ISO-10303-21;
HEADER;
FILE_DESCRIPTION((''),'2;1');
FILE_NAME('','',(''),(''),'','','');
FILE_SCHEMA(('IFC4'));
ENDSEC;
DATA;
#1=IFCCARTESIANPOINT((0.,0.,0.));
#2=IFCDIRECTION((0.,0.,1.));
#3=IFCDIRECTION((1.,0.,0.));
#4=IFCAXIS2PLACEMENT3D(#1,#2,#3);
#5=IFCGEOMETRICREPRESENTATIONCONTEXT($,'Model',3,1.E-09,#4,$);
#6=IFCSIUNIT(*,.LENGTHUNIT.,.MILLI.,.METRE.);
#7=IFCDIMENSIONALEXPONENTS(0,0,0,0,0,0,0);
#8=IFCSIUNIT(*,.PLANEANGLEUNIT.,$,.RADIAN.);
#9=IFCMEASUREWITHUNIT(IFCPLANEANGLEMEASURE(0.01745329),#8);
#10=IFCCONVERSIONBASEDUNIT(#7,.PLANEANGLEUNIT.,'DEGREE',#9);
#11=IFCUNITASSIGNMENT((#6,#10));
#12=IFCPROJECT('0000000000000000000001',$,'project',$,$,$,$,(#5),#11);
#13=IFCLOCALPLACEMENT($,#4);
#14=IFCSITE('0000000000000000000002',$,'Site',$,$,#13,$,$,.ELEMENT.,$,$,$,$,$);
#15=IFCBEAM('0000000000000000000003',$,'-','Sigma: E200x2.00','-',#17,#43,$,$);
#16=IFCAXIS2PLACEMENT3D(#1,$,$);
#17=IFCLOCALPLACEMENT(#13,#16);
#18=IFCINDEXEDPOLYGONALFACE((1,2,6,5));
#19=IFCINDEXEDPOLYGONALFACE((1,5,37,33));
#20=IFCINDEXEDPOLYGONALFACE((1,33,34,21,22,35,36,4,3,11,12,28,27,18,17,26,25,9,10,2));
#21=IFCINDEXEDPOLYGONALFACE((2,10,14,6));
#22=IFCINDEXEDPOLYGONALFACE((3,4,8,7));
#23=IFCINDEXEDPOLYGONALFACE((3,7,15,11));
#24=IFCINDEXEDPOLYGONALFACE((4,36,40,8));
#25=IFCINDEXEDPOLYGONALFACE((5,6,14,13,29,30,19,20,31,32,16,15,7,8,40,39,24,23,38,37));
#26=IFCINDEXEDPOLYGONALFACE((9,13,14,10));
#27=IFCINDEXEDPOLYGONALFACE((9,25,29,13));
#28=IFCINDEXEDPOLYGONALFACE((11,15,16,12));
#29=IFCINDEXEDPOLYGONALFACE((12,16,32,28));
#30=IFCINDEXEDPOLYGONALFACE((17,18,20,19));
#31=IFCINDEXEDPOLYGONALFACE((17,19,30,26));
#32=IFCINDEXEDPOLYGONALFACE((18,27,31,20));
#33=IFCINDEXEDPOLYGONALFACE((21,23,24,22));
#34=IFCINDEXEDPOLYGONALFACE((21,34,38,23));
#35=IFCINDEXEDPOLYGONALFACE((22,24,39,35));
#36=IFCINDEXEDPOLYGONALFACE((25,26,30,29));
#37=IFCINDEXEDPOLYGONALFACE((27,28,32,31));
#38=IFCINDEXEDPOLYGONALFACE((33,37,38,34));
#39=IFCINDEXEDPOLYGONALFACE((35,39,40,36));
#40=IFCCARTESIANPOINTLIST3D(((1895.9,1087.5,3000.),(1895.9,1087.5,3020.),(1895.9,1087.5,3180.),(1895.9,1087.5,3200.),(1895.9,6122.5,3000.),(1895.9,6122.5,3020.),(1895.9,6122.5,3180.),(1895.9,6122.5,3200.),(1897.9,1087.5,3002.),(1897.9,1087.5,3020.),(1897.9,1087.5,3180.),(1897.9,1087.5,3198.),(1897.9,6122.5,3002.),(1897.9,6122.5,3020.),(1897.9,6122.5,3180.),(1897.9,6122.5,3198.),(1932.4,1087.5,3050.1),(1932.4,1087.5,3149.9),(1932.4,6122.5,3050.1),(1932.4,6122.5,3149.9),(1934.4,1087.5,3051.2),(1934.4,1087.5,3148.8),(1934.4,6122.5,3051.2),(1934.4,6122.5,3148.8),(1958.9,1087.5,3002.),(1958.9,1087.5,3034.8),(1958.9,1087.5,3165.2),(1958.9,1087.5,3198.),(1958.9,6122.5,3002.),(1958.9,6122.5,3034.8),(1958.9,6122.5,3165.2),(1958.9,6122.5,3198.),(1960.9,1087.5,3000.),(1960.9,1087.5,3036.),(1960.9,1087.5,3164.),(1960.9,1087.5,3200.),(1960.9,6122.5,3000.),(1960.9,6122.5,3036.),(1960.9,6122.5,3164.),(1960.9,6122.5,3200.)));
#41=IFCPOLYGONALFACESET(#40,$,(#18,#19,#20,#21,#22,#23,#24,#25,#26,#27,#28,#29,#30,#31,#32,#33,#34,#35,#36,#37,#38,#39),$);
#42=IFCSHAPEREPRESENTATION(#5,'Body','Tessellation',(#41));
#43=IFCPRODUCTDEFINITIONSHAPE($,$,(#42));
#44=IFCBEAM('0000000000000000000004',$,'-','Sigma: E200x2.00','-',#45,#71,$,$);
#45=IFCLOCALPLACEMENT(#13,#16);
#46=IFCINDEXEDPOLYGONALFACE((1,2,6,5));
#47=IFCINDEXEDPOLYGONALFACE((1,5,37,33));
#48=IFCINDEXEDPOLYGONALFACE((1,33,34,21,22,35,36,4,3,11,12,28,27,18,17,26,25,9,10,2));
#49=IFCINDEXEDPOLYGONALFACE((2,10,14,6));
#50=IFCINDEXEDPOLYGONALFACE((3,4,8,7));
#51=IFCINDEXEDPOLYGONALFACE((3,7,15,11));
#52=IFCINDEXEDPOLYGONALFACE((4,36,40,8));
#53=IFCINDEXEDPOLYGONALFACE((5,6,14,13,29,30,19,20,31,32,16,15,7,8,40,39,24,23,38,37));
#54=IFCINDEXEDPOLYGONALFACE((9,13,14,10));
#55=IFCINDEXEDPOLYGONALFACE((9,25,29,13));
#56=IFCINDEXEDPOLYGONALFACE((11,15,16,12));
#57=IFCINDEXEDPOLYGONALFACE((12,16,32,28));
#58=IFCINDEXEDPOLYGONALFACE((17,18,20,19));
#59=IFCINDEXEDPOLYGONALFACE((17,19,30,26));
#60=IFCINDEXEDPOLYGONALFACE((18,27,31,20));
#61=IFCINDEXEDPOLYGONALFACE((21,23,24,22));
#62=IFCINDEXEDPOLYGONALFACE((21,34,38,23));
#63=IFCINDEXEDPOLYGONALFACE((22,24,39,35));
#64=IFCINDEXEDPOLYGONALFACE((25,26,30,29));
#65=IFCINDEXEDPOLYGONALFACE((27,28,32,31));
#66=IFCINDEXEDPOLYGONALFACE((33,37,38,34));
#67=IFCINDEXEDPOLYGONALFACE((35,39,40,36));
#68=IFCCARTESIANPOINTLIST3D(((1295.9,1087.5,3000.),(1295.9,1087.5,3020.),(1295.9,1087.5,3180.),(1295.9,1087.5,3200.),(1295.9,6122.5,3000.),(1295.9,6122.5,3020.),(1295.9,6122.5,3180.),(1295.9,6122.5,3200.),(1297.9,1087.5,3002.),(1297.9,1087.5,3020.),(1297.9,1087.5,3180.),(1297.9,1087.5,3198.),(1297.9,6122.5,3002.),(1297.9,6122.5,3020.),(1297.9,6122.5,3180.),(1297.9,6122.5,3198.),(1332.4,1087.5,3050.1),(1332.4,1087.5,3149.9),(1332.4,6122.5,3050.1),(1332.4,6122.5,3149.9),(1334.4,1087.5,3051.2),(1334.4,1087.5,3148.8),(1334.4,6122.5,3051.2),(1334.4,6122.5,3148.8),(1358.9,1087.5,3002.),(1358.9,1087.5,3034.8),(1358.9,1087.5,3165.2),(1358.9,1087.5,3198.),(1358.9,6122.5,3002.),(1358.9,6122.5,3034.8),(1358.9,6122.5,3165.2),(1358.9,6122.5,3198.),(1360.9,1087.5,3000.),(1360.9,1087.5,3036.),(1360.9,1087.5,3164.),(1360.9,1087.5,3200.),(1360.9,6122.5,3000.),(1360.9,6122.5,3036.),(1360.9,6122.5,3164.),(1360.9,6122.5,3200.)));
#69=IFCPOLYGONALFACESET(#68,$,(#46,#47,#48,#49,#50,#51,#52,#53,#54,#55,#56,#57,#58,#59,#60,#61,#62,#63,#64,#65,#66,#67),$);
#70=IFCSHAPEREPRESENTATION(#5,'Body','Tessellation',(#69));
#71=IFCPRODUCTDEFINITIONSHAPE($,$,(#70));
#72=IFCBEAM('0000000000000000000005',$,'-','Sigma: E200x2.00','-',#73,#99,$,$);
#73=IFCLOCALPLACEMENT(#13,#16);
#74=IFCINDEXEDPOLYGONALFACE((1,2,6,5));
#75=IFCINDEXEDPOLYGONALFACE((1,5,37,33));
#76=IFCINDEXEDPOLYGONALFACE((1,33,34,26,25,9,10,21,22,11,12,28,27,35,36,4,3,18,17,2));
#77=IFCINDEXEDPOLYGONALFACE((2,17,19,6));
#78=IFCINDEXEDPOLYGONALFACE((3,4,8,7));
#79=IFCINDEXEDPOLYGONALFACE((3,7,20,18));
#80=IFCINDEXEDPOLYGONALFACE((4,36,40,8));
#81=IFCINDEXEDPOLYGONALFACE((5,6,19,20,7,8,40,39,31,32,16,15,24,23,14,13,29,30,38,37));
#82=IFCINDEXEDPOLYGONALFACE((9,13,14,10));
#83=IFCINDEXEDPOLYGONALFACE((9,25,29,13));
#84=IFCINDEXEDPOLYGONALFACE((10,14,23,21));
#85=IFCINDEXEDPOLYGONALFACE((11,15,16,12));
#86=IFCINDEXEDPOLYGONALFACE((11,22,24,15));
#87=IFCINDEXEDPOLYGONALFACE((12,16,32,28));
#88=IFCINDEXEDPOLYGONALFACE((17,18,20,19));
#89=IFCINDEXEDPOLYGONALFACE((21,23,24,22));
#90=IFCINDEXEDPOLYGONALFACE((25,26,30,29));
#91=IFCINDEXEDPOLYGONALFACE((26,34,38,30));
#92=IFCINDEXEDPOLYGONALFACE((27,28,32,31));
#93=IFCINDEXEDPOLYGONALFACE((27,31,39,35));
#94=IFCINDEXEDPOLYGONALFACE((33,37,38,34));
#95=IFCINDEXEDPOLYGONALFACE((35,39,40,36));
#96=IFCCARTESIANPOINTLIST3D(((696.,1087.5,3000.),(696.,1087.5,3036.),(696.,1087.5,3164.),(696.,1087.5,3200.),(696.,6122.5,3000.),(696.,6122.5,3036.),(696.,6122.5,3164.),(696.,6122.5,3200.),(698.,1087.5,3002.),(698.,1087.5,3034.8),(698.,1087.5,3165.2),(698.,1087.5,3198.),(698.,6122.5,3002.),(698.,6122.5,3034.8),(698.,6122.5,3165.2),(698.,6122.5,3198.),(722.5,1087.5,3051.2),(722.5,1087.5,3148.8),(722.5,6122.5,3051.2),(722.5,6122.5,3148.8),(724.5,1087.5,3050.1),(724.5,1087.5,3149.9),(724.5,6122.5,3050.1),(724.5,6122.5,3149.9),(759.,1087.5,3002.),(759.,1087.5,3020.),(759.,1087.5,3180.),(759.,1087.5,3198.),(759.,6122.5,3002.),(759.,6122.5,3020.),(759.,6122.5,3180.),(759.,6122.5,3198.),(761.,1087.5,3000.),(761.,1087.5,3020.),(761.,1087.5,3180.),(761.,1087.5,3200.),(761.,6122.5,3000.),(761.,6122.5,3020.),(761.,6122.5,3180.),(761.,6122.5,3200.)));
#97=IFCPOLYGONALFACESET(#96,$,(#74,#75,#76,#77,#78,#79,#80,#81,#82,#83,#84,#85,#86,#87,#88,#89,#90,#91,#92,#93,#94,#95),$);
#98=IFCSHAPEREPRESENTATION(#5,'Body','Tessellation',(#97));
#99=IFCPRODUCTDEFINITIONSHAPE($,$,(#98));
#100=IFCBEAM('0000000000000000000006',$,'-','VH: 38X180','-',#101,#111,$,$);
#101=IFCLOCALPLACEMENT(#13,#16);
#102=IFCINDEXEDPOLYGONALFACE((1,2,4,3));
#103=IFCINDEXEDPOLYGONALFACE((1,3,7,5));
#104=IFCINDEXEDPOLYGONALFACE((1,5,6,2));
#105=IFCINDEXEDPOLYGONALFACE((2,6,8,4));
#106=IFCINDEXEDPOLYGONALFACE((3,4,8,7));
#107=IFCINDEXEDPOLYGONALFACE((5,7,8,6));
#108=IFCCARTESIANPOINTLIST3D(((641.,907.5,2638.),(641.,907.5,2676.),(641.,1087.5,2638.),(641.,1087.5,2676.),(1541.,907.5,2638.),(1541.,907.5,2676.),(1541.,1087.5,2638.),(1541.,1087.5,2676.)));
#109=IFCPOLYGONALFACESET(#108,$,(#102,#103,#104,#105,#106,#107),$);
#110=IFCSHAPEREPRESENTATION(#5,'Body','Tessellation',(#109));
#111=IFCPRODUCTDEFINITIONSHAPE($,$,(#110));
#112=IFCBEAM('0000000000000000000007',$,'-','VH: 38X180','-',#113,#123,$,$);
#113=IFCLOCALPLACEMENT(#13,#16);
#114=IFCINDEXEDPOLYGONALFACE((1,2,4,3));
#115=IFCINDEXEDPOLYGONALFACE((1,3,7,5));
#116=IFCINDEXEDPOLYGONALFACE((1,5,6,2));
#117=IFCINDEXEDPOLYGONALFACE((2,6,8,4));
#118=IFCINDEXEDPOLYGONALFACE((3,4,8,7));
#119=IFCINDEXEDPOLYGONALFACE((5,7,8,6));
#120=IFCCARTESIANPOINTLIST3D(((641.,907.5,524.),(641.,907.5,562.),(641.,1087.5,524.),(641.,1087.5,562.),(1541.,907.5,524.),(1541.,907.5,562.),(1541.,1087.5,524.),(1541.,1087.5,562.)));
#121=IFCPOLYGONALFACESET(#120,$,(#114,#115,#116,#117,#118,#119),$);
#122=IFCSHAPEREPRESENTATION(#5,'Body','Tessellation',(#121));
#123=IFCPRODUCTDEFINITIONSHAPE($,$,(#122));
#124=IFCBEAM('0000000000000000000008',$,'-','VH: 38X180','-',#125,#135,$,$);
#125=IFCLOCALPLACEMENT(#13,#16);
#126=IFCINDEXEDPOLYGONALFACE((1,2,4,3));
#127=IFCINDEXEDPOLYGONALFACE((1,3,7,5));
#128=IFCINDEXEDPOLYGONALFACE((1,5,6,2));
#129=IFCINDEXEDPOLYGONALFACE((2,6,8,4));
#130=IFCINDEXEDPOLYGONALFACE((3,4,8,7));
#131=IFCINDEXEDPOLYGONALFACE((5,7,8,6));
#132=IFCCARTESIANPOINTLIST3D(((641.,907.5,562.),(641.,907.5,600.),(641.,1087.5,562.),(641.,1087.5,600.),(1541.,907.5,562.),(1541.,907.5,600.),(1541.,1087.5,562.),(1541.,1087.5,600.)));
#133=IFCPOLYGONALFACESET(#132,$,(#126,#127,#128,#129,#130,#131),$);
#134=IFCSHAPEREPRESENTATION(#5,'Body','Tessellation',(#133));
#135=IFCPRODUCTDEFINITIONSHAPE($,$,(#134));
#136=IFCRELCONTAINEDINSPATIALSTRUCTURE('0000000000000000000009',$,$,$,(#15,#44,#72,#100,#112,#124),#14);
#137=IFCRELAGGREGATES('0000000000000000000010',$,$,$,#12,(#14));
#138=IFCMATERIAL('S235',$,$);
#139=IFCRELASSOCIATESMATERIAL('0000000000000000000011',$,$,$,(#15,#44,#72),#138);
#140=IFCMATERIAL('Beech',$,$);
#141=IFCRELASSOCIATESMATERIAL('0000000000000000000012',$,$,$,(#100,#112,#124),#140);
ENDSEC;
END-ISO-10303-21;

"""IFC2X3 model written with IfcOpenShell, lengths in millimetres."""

from ifc_helpers import new_model, entity, si_unit, converted_unit, frame, origin, origin_with_axes, origin_2d, place, context, project, spatial, polyline, rectangle, outline, extrude, material, element, save


model = new_model("IFC2X3")

# Units and contexts
model_context = context("Model", 3, precision=1e-09, world=origin_with_axes())
ifc_project = project(units=[si_unit("LENGTHUNIT", "METRE", prefix="MILLI"), converted_unit("PLANEANGLEUNIT", "DEGREE", entity("IfcPlaneAngleMeasure", 0.01745329), si_unit("PLANEANGLEUNIT", "RADIAN"), dimensions=[0, 0, 0, 0, 0, 0, 0])], contexts=[model_context])

# Site
site_placement = place(None, origin_with_axes())
site = spatial("IfcSite", under=ifc_project, at=site_placement, Name="Site", CompositionType="ELEMENT")

# Shared definitions
ifc_material_1 = material(Name="Beech")

# Beams
ifc_material_2 = material(Name="S235")
for number, where, z_axis, x_axis, name in (
    (1, (1935.0, 1087.5, 3100.0), (0.0, 1.0, 0.0), (-1.0, 0.0, 0.0), "-"),
    (2, (1335.0, 1087.5, 3100.0), (0.0, 1.0, 0.0), (-1.0, 0.0, 0.0), "-"),
):
    element("IfcBeam", number, at=place(None, frame(where, z_axis=z_axis, x_axis=x_axis)), inside=site, material=ifc_material_2, Name=name, Description="Sigma: E200x2.00", ObjectType="-", context=model_context, shape_type="SweptSolid", body=[
        extrude(outline(polyline([(39.1, -100.0), (39.1, -80.0), (37.1, -80.0), (37.1, -98.0), (-23.9, -98.0), (-23.9, -65.2), (2.6, -49.9), (2.6, 49.9), (-23.9, 65.2), (-23.9, 98.0), (37.1, 98.0), (37.1, 80.0), (39.1, 80.0), (39.1, 100.0), (-25.9, 100.0), (-25.9, 64.0), (0.6, 48.8), (0.6, -48.8), (-25.9, -64.0), (-25.9, -100.0), (39.1, -100.0)])), origin(), (0.0, 0.0, 1.0), 5035.0),
    ])
beam_1_placement = place(None, frame((721.9, 1087.5, 3100.0), z_axis=(0.0, -1.0, 0.0), x_axis=(1.0, 0.0, 0.0)))
element("IfcBeam", 3, at=beam_1_placement, inside=site, material=ifc_material_2, Name="-", Description="Sigma: E200x2.00", ObjectType="-", context=model_context, shape_type="SweptSolid", body=[
    extrude(outline(polyline([(39.1, -100.0), (39.1, -80.0), (37.1, -80.0), (37.1, -98.0), (-23.9, -98.0), (-23.9, -65.2), (2.6, -49.9), (2.6, 49.9), (-23.9, 65.2), (-23.9, 98.0), (37.1, 98.0), (37.1, 80.0), (39.1, 80.0), (39.1, 100.0), (-25.9, 100.0), (-25.9, 64.0), (0.6, 48.8), (0.6, -48.8), (-25.9, -64.0), (-25.9, -100.0), (39.1, -100.0)])), origin(), (0.0, 0.0, -1.0), 5035.0),
])
for number, where, z_axis, x_axis, name in (
    (4, (641.0, 997.5, 2657.0), (-1.0, 0.0, 0.0), (0.0, 0.0, -1.0), "-"),
    (5, (641.0, 997.5, 543.0), (-1.0, 0.0, 0.0), (0.0, 0.0, -1.0), "-"),
    (6, (641.0, 997.5, 581.0), (-1.0, 0.0, 0.0), (0.0, 0.0, -1.0), "-"),
):
    element("IfcBeam", number, at=place(None, frame(where, z_axis=z_axis, x_axis=x_axis)), inside=site, material=ifc_material_1, Name=name, Description="VH: 38X180", ObjectType="-", context=model_context, shape_type="SweptSolid", body=[
        extrude(rectangle(XDim=38.0, YDim=180.0, at=origin_2d()), origin(), (0.0, 0.0, -1.0), 900.0),
    ])

save(model, "model.ifc")
